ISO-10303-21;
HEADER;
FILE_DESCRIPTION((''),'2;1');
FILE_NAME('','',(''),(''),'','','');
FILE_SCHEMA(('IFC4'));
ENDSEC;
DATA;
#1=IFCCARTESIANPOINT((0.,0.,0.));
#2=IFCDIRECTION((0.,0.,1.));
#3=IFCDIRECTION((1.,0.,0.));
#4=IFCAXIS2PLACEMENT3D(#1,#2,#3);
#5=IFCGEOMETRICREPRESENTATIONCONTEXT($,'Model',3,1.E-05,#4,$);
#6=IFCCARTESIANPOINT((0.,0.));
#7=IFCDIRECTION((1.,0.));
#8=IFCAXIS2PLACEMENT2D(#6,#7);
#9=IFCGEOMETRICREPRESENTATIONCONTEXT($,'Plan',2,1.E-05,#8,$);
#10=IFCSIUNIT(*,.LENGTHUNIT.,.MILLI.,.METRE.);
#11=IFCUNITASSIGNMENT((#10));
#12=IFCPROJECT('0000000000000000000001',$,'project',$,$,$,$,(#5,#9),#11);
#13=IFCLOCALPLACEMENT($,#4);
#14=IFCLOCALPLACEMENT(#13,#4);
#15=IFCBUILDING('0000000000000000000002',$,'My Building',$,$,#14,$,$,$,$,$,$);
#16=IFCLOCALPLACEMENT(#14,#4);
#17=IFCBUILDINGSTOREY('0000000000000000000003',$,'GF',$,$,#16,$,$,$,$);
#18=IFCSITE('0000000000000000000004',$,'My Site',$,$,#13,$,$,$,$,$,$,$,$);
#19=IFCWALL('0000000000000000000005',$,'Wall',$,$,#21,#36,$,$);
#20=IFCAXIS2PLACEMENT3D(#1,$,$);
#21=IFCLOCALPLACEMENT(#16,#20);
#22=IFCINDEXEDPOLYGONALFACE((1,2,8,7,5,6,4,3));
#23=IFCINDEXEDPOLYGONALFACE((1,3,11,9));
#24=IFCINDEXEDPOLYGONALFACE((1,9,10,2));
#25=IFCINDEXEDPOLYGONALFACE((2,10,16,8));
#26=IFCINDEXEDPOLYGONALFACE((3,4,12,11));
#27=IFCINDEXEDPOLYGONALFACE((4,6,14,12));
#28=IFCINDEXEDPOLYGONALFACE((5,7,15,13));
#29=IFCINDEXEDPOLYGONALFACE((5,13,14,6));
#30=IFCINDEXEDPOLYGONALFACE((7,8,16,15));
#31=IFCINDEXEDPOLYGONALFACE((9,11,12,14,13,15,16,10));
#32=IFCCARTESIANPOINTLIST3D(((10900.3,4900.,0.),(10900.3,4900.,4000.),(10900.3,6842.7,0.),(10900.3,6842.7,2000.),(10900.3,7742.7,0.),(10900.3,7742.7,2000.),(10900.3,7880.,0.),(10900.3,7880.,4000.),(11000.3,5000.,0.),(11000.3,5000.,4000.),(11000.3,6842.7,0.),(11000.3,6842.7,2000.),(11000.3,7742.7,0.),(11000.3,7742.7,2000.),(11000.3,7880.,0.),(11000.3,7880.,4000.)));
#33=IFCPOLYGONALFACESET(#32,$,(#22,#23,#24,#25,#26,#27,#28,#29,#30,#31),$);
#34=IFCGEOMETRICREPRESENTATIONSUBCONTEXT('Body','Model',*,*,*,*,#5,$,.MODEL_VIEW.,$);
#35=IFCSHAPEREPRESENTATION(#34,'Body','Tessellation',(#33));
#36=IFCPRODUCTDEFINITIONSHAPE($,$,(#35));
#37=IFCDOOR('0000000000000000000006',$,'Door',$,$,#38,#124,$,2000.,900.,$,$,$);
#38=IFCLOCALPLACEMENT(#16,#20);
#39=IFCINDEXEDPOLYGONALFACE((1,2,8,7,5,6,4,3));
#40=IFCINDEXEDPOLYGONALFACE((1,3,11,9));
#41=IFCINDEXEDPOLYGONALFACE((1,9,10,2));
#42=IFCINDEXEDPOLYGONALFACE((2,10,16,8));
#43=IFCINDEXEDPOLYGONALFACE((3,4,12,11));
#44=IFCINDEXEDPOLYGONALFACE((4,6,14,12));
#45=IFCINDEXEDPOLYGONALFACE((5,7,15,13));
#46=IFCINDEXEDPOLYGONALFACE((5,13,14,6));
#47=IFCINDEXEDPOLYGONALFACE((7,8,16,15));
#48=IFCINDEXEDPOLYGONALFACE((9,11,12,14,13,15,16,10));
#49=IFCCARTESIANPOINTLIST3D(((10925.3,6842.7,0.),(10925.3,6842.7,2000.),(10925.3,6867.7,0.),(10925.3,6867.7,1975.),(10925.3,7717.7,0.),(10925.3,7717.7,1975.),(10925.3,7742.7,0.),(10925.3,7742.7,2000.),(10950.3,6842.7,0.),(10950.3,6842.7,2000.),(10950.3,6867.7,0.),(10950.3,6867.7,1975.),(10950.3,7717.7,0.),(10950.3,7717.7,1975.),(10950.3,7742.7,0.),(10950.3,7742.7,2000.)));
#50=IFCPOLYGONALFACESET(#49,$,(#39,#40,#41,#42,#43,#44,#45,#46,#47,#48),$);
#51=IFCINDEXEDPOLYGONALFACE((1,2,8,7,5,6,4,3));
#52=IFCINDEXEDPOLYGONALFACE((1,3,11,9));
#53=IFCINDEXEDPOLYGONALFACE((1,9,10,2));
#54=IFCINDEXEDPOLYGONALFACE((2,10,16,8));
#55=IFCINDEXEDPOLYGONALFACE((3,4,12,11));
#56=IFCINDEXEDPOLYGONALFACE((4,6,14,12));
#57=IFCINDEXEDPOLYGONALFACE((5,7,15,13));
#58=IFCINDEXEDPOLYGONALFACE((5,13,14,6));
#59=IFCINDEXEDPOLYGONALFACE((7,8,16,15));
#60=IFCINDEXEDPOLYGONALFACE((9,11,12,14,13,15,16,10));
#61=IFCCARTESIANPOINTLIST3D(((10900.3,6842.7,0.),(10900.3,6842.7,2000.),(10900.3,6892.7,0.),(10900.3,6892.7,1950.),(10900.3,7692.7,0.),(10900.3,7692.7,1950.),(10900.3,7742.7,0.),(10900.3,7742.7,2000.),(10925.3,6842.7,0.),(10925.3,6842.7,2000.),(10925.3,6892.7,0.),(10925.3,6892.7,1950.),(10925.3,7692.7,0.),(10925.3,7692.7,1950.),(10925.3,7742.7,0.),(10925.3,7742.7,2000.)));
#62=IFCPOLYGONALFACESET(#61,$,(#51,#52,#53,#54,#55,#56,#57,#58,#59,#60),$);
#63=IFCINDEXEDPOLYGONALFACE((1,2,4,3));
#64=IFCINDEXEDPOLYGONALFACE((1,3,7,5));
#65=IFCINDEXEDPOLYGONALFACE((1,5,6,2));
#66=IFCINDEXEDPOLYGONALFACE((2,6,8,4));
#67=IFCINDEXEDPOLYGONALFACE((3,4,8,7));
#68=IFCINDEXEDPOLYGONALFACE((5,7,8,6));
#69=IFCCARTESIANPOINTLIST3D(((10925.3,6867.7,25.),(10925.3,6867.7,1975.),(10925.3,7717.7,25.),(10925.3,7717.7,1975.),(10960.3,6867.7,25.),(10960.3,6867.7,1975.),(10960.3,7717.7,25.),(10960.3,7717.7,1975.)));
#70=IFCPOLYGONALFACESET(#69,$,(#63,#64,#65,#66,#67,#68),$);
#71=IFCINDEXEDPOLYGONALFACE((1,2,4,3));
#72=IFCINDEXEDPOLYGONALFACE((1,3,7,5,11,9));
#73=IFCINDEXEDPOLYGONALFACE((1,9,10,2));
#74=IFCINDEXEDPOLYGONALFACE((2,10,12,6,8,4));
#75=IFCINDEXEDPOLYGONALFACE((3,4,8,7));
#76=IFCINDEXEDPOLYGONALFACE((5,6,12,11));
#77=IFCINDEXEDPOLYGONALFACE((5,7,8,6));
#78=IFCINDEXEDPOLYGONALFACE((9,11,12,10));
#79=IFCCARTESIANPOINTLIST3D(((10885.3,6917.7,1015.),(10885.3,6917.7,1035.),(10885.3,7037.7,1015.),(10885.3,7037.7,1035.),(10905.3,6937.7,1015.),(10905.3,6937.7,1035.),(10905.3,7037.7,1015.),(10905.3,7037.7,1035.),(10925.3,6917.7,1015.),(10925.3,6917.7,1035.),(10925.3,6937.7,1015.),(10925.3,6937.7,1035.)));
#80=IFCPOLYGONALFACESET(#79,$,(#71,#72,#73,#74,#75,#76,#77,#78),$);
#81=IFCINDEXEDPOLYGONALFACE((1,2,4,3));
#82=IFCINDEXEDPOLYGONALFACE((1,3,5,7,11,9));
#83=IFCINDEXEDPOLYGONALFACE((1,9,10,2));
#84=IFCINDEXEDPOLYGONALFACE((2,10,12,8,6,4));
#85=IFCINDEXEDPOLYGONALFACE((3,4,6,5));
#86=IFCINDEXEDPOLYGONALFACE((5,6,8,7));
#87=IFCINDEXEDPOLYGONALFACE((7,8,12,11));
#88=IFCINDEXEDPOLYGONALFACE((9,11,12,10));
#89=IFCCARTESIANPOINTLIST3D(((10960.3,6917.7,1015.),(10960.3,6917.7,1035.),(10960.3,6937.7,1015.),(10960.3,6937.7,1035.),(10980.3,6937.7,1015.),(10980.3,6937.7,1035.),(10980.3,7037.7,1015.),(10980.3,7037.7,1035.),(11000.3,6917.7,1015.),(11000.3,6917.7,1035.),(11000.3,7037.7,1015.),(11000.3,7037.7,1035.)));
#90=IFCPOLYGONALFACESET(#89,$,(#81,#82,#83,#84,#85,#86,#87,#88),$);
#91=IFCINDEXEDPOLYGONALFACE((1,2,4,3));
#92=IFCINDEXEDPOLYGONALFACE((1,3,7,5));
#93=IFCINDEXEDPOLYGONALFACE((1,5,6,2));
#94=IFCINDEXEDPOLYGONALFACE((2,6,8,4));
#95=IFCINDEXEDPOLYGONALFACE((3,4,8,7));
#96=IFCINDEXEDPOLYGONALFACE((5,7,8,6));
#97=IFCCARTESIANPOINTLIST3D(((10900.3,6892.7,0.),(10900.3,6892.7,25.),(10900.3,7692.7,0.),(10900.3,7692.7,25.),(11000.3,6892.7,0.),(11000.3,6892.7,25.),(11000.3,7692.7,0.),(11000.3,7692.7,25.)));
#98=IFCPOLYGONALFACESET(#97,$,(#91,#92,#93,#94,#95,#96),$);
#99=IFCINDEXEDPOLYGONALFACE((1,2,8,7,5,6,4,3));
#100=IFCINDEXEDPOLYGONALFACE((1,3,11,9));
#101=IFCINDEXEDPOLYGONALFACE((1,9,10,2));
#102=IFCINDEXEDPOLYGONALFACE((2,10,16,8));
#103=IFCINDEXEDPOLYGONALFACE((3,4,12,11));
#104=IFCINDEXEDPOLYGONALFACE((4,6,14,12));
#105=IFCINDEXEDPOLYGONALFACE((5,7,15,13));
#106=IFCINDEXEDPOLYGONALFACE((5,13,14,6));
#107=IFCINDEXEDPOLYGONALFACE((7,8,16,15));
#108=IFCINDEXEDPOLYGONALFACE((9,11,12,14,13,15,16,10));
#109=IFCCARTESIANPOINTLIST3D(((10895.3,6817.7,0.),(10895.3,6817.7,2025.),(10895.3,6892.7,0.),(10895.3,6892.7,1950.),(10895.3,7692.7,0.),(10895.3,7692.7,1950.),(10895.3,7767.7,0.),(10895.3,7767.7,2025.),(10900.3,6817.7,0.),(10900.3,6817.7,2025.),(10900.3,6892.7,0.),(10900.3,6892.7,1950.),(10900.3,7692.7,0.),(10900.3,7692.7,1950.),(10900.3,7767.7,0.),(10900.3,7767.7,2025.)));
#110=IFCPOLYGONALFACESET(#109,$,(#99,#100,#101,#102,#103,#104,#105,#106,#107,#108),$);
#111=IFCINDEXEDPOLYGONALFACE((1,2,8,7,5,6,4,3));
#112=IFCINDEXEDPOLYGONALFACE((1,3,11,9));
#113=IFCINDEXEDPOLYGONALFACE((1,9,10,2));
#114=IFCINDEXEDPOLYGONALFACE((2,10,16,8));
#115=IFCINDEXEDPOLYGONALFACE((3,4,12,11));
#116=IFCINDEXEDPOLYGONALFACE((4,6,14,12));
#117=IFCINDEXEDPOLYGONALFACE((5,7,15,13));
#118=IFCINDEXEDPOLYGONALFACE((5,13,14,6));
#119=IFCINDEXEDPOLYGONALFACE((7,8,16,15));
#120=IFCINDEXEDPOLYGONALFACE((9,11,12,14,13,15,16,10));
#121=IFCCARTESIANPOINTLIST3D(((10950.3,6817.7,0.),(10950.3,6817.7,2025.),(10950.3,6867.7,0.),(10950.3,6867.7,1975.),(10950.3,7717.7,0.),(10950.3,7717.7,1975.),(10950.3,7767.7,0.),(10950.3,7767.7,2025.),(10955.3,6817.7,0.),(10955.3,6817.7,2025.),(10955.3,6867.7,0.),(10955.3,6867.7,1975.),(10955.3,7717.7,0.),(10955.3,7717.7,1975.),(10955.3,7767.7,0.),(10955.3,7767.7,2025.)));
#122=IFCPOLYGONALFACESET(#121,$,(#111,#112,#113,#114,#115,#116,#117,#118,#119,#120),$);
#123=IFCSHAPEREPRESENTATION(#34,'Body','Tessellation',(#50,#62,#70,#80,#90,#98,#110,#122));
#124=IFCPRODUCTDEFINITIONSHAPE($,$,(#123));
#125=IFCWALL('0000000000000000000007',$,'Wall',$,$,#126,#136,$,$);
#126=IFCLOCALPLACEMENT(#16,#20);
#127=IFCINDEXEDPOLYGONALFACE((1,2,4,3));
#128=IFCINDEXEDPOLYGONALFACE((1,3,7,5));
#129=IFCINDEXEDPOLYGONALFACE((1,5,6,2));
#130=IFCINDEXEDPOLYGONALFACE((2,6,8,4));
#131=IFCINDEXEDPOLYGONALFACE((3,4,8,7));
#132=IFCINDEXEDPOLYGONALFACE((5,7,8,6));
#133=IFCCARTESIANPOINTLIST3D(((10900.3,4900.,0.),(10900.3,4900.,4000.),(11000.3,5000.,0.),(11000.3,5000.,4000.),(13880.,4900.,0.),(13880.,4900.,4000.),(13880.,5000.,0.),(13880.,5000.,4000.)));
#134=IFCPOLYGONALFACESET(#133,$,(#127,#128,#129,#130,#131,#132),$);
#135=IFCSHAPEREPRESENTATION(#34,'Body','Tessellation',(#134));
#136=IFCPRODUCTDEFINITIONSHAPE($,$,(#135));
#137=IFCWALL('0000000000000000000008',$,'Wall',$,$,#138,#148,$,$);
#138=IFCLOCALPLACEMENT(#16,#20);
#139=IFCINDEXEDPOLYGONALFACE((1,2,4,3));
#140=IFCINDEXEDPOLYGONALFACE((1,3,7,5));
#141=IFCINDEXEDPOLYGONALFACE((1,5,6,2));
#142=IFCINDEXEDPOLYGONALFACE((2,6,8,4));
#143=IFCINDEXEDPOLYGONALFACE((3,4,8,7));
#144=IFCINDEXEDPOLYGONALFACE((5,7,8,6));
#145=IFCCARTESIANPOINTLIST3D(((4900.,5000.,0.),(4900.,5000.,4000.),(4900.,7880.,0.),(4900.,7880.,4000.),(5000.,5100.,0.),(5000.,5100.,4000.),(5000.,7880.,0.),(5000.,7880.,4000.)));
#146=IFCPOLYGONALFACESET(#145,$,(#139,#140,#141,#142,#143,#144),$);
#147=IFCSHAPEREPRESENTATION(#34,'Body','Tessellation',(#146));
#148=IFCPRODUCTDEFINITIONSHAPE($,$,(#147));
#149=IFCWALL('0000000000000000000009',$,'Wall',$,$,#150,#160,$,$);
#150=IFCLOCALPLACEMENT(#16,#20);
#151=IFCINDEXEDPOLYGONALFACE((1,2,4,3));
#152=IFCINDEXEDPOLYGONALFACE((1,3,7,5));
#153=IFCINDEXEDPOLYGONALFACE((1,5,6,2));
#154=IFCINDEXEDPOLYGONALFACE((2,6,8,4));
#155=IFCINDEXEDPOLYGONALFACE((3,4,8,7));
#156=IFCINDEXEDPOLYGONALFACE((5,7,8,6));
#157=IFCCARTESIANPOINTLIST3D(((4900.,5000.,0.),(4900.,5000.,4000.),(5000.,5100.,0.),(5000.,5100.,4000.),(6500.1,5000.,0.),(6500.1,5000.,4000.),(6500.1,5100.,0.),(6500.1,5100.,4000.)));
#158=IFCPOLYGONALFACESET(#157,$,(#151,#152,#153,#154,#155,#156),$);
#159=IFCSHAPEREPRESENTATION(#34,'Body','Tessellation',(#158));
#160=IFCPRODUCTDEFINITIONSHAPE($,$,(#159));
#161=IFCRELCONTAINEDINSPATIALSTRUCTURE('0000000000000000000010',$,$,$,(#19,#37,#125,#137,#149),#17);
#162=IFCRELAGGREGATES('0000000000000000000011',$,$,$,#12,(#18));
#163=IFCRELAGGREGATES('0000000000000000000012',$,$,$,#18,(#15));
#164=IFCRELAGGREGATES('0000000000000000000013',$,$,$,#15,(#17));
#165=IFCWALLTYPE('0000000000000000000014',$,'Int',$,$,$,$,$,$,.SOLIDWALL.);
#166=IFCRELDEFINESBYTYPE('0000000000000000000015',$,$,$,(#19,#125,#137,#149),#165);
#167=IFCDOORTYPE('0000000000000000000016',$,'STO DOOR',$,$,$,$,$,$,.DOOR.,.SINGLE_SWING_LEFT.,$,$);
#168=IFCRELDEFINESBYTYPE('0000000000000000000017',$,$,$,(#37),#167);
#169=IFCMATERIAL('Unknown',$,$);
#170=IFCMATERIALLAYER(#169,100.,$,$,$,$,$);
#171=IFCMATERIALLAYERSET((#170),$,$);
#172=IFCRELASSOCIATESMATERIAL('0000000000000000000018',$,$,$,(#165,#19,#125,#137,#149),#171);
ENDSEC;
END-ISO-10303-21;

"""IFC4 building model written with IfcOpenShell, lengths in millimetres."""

from ifc_helpers import new_model, entity, si_unit, frame, origin_with_axes, origin_2d_with_axis, place, context, subcontext, project, spatial, line, indexed_curve, outline, extrude, shape, source, transform, mapped, material, layer, layer_set, layer_usage, type_object, type_shapes, element, fill, save


model = new_model("IFC4")

# Units and contexts
model_context = context("Model", 3, precision=1e-05, world=origin_with_axes())
plan_context = context("Plan", 2, precision=1e-05, world=origin_2d_with_axis())
body_context_1 = subcontext(model_context, "Body", "Model", "MODEL_VIEW")
body_context_2 = subcontext(plan_context, "Body", "Plan", "PLAN_VIEW")
ifc_project = project(units=[si_unit("LENGTHUNIT", "METRE", prefix="MILLI")], contexts=[model_context, plan_context])

# Site, building, storey
site_placement = place(None, origin_with_axes())
site = spatial("IfcSite", under=ifc_project, at=site_placement, Name="My Site")
building_placement = place(site_placement, origin_with_axes())
building = spatial("IfcBuilding", under=site, at=building_placement, Name="My Building")
storey_placement = place(building_placement, origin_with_axes())
storey = spatial("IfcBuildingStorey", under=building, at=storey_placement, Name="GF")

# Shared definitions
ifc_material = material(Name="Unknown")

# Shared definitions
ifc_layer_1 = layer(ifc_material, 100.0)
ifc_layer_set_1 = layer_set([ifc_layer_1])
wall_type_1 = type_object("IfcWallType", Name="Int", PredefinedType="SOLIDWALL", material=ifc_layer_set_1)

# Wall, opening, door
ifc_layer_usage_1 = layer_usage(ifc_layer_set_1, "AXIS2", "POSITIVE", 0.0)
wall_1_placement = place(storey_placement, frame((11000.3, 4900.0, 0.0), z_axis=(0.0, 0.0, 1.0), x_axis=(0.0, 1.0, 0.0)))
wall_1 = element("IfcWall", 1, at=wall_1_placement, inside=storey, type_object=wall_type_1, material=ifc_layer_usage_1, Name="Wall", context=body_context_1, shape_type="SweptSolid", body=[
    extrude(outline(indexed_curve([(100.0, 0.0), (0.0, 100.0), (2980.0, 100.0), (2980.0, 0.0)], segments=[line(1, 2, 3, 4, 1)])), origin_with_axes(), (0.0, 0.0, 1.0), 4000.0),
])
shared_shape_1 = source(origin_with_axes(), body_context_1, "Body", "SweptSolid", [
    extrude(outline(indexed_curve([(0.0, 0.0), (900.0, 0.0), (900.0, 2000.0), (0.0, 2000.0)], segments=[line(1, 2, 3, 4, 1)])), frame((0.0, -600.0, 0.0), z_axis=(0.0, -1.0, 0.0), x_axis=(1.0, 0.0, 0.0)), (0.0, 0.0, -1.0), 1200.0),
])
opening_1_placement = place(wall_1_placement, frame((2842.7, 100.0, 0.0), z_axis=(0.0, 0.0, 1.0), x_axis=(-1.0, 0.0, 0.0)))
opening_1 = element("IfcOpeningElement", 2, at=opening_1_placement, cuts=wall_1, PredefinedType="OPENING", context=body_context_1, shape_type="MappedRepresentation", body=[
    mapped(shared_shape_1, transform((0.0, 0.0, 0.0), x_axis=(1.0, 0.0, 0.0), y_axis=(0.0, 1.0, 0.0), z_axis=(0.0, 0.0, 1.0), scale=1.0)),
])
door_type_1 = type_object("IfcDoorType", Name="STO DOOR", OperationType="SINGLE_SWING_LEFT", PredefinedType="DOOR")
shared_shape_2 = source(origin_with_axes(), body_context_1, "Body", "SweptSolid", [
    extrude(outline(indexed_curve([(0.0, 0.0), (0.0, 2000.0), (900.0, 2000.0), (900.0, 0.0), (875.0, 0.0), (875.0, 1975.0), (25.0, 1975.0), (25.0, 0.0)], segments=[line(1, 2, 3, 4, 5, 6, 7, 8, 1)])), frame((0.0, 25.0, 0.0), z_axis=(0.0, -1.0, 0.0), x_axis=(1.0, 0.0, 0.0)), (0.0, 0.0, -1.0), 25.0),
    extrude(outline(indexed_curve([(0.0, 0.0), (0.0, 2000.0), (900.0, 2000.0), (900.0, 0.0), (850.0, 0.0), (850.0, 1950.0), (50.0, 1950.0), (50.0, 0.0)], segments=[line(1, 2, 3, 4, 5, 6, 7, 8, 1)])), frame((0.0, 0.0, 0.0), z_axis=(0.0, -1.0, 0.0), x_axis=(1.0, 0.0, 0.0)), (0.0, 0.0, -1.0), 25.0),
    extrude(outline(indexed_curve([(0.0, 0.0), (850.0, 0.0), (850.0, 35.0), (0.0, 35.0)], segments=[line(1, 2, 3, 4, 1)])), frame((25.0, 25.0, 25.0), z_axis=(0.0, 0.0, 1.0), x_axis=(1.0, 0.0, 0.0)), (0.0, 0.0, 1.0), 1950.0),
    extrude(outline(indexed_curve([(0.0, 0.0), (0.0, -40.0), (-120.0, -40.0), (-120.0, -20.0), (-20.0, -20.0), (-20.0, 0.0)], segments=[line(1, 2, 3, 4, 5, 6, 1)])), frame((825.0, 25.0, 1015.0), z_axis=(0.0, 0.0, 1.0), x_axis=(1.0, 0.0, 0.0)), (0.0, 0.0, 1.0), 20.0),
    extrude(outline(indexed_curve([(0.0, 0.0), (0.0, 40.0), (-120.0, 40.0), (-120.0, 20.0), (-20.0, 20.0), (-20.0, 0.0)], segments=[line(1, 2, 3, 4, 5, 6, 1)])), frame((825.0, 60.0, 1015.0), z_axis=(0.0, 0.0, 1.0), x_axis=(1.0, 0.0, 0.0)), (0.0, 0.0, 1.0), 20.0),
    extrude(outline(indexed_curve([(0.0, 0.0), (800.0, 0.0), (800.0, 100.0), (0.0, 100.0)], segments=[line(1, 2, 3, 4, 1)])), frame((50.0, 0.0, 0.0), z_axis=(0.0, 0.0, 1.0), x_axis=(1.0, 0.0, 0.0)), (0.0, 0.0, 1.0), 25.0),
    extrude(outline(indexed_curve([(0.0, 0.0), (0.0, 2025.0), (950.0, 2025.0), (950.0, 0.0), (875.0, 0.0), (875.0, 1950.0), (75.0, 1950.0), (75.0, 0.0)], segments=[line(1, 2, 3, 4, 5, 6, 7, 8, 1)])), frame((-25.0, -5.0, 0.0), z_axis=(0.0, -1.0, 0.0), x_axis=(1.0, 0.0, 0.0)), (0.0, 0.0, -1.0), 5.0),
    extrude(outline(indexed_curve([(0.0, 0.0), (0.0, 2025.0), (950.0, 2025.0), (950.0, 0.0), (900.0, 0.0), (900.0, 1975.0), (50.0, 1975.0), (50.0, 0.0)], segments=[line(1, 2, 3, 4, 5, 6, 7, 8, 1)])), frame((-25.0, 50.0, 0.0), z_axis=(0.0, -1.0, 0.0), x_axis=(1.0, 0.0, 0.0)), (0.0, 0.0, -1.0), 5.0),
])
shared_shape_3 = source(origin_with_axes(), body_context_2, "Body", "Curve2D", [
    entity("IfcIndexedPolyCurve", entity("IfcCartesianPointList2D", [[0.0, 0.0], [0.0, 50.0], [25.0, 50.0], [25.0, 25.0], [50.0, 25.0], [50.0, 0.0]]), [entity("IfcLineIndex", [1, 2, 3, 4, 5, 6, 1])]),
    entity("IfcIndexedPolyCurve", entity("IfcCartesianPointList2D", [[900.0, 0.0], [900.0, 50.0], [875.0, 50.0], [875.0, 25.0], [850.0, 25.0], [850.0, 0.0]]), [entity("IfcLineIndex", [1, 2, 3, 4, 5, 6, 1])]),
    entity("IfcTrimmedCurve", entity("IfcEllipse", entity("IfcAxis2Placement2D", entity("IfcCartesianPoint", [60.0, 50.0]), entity("IfcDirection", [1.0, 0.0])), 815.0, 850.0), [entity("IfcCartesianPoint", [875.0, 50.0])], [entity("IfcCartesianPoint", [60.0, 900.0])], True, "CARTESIAN"),
    entity("IfcIndexedPolyCurve", entity("IfcCartesianPointList2D", [[25.0, 50.0], [60.0, 50.0], [60.0, 900.0], [25.0, 900.0]]), [entity("IfcLineIndex", [1, 2, 3, 4, 1])]),
])
type_shapes(door_type_1, [shared_shape_2, shared_shape_3])
door_1_placement = place(opening_1_placement, frame((0.0, 0.0, 0.0), z_axis=(0.0, 0.0, 1.0), x_axis=(1.0, 0.0, 0.0)))
door_1 = element("IfcDoor", 3, at=door_1_placement, inside=storey, type_object=door_type_1, Name="Door", OverallHeight=2000.0, OverallWidth=900.0, shapes=[
    shape(body_context_1, "Body", "MappedRepresentation", [mapped(shared_shape_2, transform((0.0, 0.0, 0.0), x_axis=(1.0, 0.0, 0.0), y_axis=(0.0, 1.0, 0.0), z_axis=(0.0, 0.0, 1.0), scale=1.0))]),
    shape(body_context_2, "Body", "MappedRepresentation", [mapped(shared_shape_3, transform((0.0, 0.0, 0.0), x_axis=(1.0, 0.0, 0.0), y_axis=(0.0, 1.0, 0.0), z_axis=(0.0, 0.0, 1.0), scale=1.0))]),
])
fill(opening_1, door_1)

# Walls
ifc_layer_usage_2 = layer_usage(ifc_layer_set_1, "AXIS2", "POSITIVE", 0.0)
wall_2_placement = place(storey_placement, frame((11000.3, 4900.0, 0.0), z_axis=(0.0, 0.0, 1.0), x_axis=(1.0, 0.0, 0.0)))
element("IfcWall", 4, at=wall_2_placement, inside=storey, type_object=wall_type_1, material=ifc_layer_usage_2, Name="Wall", context=body_context_1, shape_type="SweptSolid", body=[
    extrude(outline(indexed_curve([(-100.0, 0.0), (0.0, 100.0), (2879.7, 100.0), (2879.7, 0.0)], segments=[line(1, 2, 3, 4, 1)])), origin_with_axes(), (0.0, 0.0, 1.0), 4000.0),
])
ifc_layer_usage_3 = layer_usage(ifc_layer_set_1, "AXIS2", "POSITIVE", 0.0)
wall_3_placement = place(storey_placement, frame((5000.0, 5000.0, 0.0), z_axis=(0.0, 0.0, 1.0), x_axis=(0.0, 1.0, 0.0)))
element("IfcWall", 5, at=wall_3_placement, inside=storey, type_object=wall_type_1, material=ifc_layer_usage_3, Name="Wall", context=body_context_1, shape_type="SweptSolid", body=[
    extrude(outline(indexed_curve([(100.0, 0.0), (0.0, 100.0), (2880.0, 100.0), (2880.0, 0.0)], segments=[line(1, 2, 3, 4, 1)])), origin_with_axes(), (0.0, 0.0, 1.0), 4000.0),
])
ifc_layer_usage_4 = layer_usage(ifc_layer_set_1, "AXIS2", "POSITIVE", 0.0)
wall_4_placement = place(storey_placement, frame((5000.0, 5000.0, 0.0), z_axis=(0.0, 0.0, 1.0), x_axis=(1.0, 0.0, 0.0)))
element("IfcWall", 6, at=wall_4_placement, inside=storey, type_object=wall_type_1, material=ifc_layer_usage_4, Name="Wall", context=body_context_1, shape_type="SweptSolid", body=[
    extrude(outline(indexed_curve([(-100.0, 0.0), (0.0, 100.0), (1500.1, 100.0), (1500.1, 0.0)], segments=[line(1, 2, 3, 4, 1)])), origin_with_axes(), (0.0, 0.0, 1.0), 4000.0),
])

save(model, "model.ifc")
